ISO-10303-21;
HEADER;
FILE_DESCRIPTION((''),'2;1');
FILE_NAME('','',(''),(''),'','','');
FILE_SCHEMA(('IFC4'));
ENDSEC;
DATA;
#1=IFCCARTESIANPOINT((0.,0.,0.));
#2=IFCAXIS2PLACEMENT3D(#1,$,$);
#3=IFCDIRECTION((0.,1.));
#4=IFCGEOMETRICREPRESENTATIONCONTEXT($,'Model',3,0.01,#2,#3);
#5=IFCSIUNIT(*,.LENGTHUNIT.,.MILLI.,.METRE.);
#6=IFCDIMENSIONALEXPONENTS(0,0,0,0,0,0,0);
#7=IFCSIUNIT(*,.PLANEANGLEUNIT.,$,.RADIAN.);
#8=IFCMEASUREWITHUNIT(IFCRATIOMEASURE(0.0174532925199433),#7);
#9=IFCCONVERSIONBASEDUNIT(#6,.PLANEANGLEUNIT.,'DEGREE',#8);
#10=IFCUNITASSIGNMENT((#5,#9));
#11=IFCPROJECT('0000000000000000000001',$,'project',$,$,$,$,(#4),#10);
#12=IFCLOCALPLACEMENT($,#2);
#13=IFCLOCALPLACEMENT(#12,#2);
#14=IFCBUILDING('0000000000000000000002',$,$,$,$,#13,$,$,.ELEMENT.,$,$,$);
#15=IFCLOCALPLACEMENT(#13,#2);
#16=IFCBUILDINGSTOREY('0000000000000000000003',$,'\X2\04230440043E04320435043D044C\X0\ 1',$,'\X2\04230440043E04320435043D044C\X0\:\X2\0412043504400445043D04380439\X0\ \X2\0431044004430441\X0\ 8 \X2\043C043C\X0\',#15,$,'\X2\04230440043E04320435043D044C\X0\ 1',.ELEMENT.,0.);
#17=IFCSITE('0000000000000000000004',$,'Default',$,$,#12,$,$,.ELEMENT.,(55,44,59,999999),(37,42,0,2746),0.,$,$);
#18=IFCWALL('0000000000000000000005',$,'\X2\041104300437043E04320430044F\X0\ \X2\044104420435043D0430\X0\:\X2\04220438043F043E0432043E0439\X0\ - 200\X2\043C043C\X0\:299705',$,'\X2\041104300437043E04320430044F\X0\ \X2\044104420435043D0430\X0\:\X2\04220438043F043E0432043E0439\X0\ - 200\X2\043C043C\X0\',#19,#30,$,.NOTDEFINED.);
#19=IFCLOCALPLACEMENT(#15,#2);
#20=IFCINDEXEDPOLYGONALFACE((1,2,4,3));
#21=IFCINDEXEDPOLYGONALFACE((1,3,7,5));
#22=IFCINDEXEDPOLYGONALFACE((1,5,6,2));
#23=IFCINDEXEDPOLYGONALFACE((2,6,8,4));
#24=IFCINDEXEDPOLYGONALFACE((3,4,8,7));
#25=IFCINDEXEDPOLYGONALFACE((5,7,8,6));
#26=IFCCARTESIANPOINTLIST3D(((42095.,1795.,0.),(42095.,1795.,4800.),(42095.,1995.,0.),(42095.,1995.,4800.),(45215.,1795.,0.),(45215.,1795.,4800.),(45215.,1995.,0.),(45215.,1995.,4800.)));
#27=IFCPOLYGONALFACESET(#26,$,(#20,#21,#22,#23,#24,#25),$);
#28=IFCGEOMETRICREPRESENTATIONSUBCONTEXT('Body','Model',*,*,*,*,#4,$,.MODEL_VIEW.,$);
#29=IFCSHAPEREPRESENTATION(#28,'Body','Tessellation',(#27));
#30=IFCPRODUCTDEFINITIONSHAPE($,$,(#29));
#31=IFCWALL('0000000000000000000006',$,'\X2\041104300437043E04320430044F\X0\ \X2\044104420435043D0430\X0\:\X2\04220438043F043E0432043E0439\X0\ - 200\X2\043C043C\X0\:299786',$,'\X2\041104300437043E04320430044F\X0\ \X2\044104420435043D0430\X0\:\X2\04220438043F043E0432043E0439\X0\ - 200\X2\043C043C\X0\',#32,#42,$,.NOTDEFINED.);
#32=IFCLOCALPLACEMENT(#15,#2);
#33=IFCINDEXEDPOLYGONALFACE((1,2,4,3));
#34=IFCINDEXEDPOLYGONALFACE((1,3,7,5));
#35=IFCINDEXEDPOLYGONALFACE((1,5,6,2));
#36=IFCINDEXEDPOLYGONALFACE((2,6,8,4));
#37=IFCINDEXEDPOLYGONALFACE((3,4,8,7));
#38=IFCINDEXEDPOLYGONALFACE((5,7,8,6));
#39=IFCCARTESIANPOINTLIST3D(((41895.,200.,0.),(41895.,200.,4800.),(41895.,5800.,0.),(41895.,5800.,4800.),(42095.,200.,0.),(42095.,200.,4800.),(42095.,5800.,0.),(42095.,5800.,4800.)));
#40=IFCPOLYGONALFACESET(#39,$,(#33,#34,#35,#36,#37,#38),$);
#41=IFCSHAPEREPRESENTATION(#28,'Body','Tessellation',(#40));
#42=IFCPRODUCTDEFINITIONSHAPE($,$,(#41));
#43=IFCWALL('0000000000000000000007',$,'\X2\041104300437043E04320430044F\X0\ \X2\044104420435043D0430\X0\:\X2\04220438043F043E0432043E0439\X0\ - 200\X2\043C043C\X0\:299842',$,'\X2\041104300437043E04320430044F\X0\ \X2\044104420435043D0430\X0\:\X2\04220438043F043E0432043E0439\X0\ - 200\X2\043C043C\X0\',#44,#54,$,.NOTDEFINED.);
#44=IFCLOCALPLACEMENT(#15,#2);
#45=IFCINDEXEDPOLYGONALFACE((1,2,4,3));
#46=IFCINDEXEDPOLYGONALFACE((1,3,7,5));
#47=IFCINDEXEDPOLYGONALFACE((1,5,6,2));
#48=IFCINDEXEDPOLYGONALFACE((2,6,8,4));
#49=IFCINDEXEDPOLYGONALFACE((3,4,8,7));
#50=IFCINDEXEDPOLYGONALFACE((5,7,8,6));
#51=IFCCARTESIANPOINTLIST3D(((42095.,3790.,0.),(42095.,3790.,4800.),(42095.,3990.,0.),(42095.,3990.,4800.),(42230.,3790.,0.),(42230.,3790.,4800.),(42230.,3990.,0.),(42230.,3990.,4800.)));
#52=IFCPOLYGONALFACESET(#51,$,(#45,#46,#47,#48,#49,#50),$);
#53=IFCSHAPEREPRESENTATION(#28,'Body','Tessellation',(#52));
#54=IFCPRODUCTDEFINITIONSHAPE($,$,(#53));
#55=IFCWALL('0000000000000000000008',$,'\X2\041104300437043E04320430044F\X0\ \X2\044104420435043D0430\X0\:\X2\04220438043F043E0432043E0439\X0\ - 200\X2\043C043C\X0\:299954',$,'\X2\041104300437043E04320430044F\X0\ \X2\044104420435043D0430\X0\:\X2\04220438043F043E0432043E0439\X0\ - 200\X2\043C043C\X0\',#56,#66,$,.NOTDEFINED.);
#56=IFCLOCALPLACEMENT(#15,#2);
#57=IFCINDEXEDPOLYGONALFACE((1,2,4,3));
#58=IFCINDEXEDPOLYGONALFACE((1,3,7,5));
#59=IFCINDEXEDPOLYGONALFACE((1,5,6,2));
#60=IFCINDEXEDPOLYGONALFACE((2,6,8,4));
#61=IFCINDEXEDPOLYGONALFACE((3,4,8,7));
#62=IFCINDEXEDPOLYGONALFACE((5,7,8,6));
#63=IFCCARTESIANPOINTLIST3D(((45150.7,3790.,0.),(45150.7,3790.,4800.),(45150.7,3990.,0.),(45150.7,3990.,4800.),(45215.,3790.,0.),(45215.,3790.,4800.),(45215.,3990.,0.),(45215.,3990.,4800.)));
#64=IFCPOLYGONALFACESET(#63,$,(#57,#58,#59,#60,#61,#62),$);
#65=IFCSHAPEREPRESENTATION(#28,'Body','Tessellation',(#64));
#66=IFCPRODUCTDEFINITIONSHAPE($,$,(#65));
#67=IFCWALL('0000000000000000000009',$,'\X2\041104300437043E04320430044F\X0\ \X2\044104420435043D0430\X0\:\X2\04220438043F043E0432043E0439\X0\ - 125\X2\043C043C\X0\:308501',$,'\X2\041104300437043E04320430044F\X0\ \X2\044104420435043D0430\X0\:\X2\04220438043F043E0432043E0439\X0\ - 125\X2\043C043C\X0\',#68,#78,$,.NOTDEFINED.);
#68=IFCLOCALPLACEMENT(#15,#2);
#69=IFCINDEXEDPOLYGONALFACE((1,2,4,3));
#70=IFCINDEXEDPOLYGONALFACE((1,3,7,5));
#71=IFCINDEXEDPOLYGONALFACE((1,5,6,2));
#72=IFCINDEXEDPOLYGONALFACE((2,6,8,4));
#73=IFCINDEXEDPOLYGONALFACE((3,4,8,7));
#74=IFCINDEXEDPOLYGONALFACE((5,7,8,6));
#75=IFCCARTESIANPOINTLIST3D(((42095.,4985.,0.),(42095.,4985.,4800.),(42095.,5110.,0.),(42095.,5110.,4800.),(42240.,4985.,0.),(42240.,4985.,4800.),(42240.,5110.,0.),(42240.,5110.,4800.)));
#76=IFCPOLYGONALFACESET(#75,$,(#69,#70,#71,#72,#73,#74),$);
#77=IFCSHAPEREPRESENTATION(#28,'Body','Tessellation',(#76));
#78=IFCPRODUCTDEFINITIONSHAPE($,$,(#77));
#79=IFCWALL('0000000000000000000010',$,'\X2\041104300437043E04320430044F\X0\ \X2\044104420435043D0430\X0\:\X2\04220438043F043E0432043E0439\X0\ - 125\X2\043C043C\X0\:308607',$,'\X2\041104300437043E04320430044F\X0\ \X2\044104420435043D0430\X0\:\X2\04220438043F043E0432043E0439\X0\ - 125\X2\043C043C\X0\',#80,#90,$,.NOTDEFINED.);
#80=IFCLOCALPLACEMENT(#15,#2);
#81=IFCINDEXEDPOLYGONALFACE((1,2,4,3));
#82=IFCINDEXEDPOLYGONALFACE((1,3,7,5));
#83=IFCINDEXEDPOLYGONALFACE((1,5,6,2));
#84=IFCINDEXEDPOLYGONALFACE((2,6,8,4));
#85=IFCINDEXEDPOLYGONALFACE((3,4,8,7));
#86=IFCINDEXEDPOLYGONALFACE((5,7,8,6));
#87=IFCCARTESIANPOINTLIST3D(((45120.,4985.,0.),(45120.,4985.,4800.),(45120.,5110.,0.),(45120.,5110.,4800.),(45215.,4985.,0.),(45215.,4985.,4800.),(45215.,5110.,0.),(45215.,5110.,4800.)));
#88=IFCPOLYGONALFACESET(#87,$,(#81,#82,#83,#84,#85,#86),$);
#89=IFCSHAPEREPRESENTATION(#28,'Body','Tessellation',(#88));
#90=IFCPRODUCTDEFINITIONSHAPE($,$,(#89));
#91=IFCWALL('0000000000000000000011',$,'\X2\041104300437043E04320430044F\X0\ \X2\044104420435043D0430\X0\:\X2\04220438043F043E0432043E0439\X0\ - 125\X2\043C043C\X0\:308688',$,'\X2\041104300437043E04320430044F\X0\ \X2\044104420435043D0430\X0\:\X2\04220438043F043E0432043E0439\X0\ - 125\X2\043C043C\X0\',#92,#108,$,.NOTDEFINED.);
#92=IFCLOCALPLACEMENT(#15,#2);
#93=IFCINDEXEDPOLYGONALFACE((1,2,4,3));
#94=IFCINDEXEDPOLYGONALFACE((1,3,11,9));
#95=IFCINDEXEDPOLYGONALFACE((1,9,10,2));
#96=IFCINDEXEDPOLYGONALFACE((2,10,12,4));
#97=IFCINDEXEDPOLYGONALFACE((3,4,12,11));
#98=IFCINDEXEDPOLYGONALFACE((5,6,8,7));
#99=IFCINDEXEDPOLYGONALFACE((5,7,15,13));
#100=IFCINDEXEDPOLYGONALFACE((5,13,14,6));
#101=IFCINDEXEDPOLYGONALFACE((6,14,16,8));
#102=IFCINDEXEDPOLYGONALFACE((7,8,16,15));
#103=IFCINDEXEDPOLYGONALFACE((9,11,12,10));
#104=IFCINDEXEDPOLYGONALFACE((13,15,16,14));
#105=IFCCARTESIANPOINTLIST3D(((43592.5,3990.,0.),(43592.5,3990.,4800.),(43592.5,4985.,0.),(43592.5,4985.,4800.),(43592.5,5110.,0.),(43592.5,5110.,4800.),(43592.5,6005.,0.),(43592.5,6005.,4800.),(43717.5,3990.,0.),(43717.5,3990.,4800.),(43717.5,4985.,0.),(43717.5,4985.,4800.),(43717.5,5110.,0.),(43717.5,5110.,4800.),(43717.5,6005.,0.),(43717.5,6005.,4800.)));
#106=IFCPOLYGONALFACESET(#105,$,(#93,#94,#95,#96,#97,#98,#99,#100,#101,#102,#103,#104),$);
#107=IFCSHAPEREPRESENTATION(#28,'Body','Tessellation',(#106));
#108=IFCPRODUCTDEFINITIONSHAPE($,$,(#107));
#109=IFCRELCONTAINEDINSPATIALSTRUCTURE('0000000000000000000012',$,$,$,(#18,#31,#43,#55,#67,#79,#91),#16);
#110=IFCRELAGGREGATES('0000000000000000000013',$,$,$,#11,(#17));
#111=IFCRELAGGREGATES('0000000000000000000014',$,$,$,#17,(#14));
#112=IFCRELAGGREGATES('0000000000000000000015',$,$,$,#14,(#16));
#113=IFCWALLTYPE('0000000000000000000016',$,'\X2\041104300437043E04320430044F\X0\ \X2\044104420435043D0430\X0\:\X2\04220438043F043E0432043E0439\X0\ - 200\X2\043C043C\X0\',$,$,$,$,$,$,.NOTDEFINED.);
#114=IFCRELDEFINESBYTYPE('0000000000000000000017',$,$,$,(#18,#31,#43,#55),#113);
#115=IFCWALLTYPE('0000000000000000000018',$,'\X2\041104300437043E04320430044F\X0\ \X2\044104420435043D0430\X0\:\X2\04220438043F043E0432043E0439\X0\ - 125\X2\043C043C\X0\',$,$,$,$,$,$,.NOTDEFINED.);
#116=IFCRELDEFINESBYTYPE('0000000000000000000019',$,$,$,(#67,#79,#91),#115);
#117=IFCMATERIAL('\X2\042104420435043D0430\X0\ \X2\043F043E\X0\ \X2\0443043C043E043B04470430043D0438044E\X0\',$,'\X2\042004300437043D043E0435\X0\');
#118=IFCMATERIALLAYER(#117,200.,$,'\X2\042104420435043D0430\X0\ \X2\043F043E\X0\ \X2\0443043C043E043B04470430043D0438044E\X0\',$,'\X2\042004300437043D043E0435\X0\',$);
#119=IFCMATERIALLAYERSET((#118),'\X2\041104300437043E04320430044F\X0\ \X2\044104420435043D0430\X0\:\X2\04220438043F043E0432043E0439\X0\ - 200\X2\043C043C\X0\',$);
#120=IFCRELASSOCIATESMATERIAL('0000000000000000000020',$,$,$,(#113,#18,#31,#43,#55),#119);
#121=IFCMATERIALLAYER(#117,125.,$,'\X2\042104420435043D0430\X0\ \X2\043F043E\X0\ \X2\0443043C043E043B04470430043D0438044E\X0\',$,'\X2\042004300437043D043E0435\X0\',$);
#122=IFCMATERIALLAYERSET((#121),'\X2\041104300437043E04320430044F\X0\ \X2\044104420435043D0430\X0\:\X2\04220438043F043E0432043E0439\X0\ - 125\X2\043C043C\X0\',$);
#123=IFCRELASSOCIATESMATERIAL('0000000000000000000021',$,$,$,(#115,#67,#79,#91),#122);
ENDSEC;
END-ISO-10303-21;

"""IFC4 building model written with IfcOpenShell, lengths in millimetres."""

from ifc_helpers import new_model, entity, si_unit, converted_unit, direction, frame, frame_2d, origin, place, context, subcontext, project, spatial, rectangle, extrude, material, layer, layer_set, layer_usage, type_object, element, save


model = new_model("IFC4")

# Units and contexts
model_context = context("Model", 3, precision=0.01, world=origin(), true_north=direction((0.0, 1.0)))
body_context = subcontext(model_context, "Body", "Model", "MODEL_VIEW")
ifc_project = project(units=[si_unit("LENGTHUNIT", "METRE", prefix="MILLI"), converted_unit("PLANEANGLEUNIT", "DEGREE", entity("IfcRatioMeasure", 0.0174532925199433), si_unit("PLANEANGLEUNIT", "RADIAN"), dimensions=[0, 0, 0, 0, 0, 0, 0])], contexts=[model_context])

# Site, building, storey
site_placement = place(None, origin())
site = spatial("IfcSite", under=ifc_project, at=site_placement, Name="Default", CompositionType="ELEMENT", RefLatitude=(55, 44, 59, 999999), RefLongitude=(37, 42, 0, 2746), RefElevation=0.0)
building_placement = place(site_placement, origin())
building = spatial("IfcBuilding", under=site, at=building_placement, CompositionType="ELEMENT")
storey_placement = place(building_placement, origin())
storey = spatial("IfcBuildingStorey", under=building, at=storey_placement, Name="Уровень 1", ObjectType="Уровень:Верхний брус 8 мм", LongName="Уровень 1", CompositionType="ELEMENT", Elevation=0.0)

# Shared definitions
ifc_material_1 = material(Name="Стена по умолчанию", Category="Разное")
ifc_layer_1 = layer(ifc_material_1, 200.0, Name="Стена по умолчанию", Category="Разное")
ifc_layer_set_1 = layer_set([ifc_layer_1], Name="Базовая стена:Типовой - 200мм")
wall_type_1 = type_object("IfcWallType", Name="Базовая стена:Типовой - 200мм", PredefinedType="NOTDEFINED", material=ifc_layer_set_1)

# Walls
ifc_layer_usage_1 = layer_usage(ifc_layer_set_1, "AXIS2", "NEGATIVE", 100.0)
wall_1_placement = place(storey_placement, frame((45215.0, 1895.0, 0.0), z_axis=(0.0, 0.0, 1.0), x_axis=(-1.0, 0.0, 0.0)))
element("IfcWall", 1, at=wall_1_placement, inside=storey, type_object=wall_type_1, material=ifc_layer_usage_1, Name="Базовая стена:Типовой - 200мм:299705", ObjectType="Базовая стена:Типовой - 200мм", PredefinedType="NOTDEFINED", context=body_context, shape_type="SweptSolid", body=[
    extrude(rectangle(XDim=3120.0, YDim=200.0, at=frame_2d((1560.0, 0.0), x_axis=(-1.0, 0.0))), origin(), (0.0, 0.0, 1.0), 4800.0),
])
ifc_layer_usage_2 = layer_usage(ifc_layer_set_1, "AXIS2", "NEGATIVE", 100.0)
wall_2_placement = place(storey_placement, frame((41995.0, 5800.0, 0.0), z_axis=(0.0, 0.0, 1.0), x_axis=(0.0, -1.0, 0.0)))
element("IfcWall", 2, at=wall_2_placement, inside=storey, type_object=wall_type_1, material=ifc_layer_usage_2, Name="Базовая стена:Типовой - 200мм:299786", ObjectType="Базовая стена:Типовой - 200мм", PredefinedType="NOTDEFINED", context=body_context, shape_type="SweptSolid", body=[
    extrude(rectangle(XDim=5600.0, YDim=200.0, at=frame_2d((2800.0, 0.0), x_axis=(-1.0, 0.0))), origin(), (0.0, 0.0, 1.0), 4800.0),
])
ifc_layer_usage_3 = layer_usage(ifc_layer_set_1, "AXIS2", "NEGATIVE", 100.0)
wall_3_placement = place(storey_placement, frame((42095.0, 3890.0, 0.0)))
element("IfcWall", 3, at=wall_3_placement, inside=storey, type_object=wall_type_1, material=ifc_layer_usage_3, Name="Базовая стена:Типовой - 200мм:299842", ObjectType="Базовая стена:Типовой - 200мм", PredefinedType="NOTDEFINED", context=body_context, shape_type="SweptSolid", body=[
    extrude(rectangle(XDim=135.0, YDim=200.0, at=frame_2d((67.5, 0.0), x_axis=(-1.0, 0.0))), origin(), (0.0, 0.0, 1.0), 4800.0),
])

# Walls
ifc_layer_usage_4 = layer_usage(ifc_layer_set_1, "AXIS2", "NEGATIVE", 100.0)
wall_4_placement = place(storey_placement, frame((45150.7, 3890.0, 0.0)))
element("IfcWall", 4, at=wall_4_placement, inside=storey, type_object=wall_type_1, material=ifc_layer_usage_4, Name="Базовая стена:Типовой - 200мм:299954", ObjectType="Базовая стена:Типовой - 200мм", PredefinedType="NOTDEFINED", context=body_context, shape_type="SweptSolid", body=[
    extrude(rectangle(XDim=64.3, YDim=200.0, at=frame_2d((32.1, 0.0), x_axis=(-1.0, 0.0))), origin(), (0.0, 0.0, 1.0), 4800.0),
])
ifc_layer_2 = layer(ifc_material_1, 125.0, Name="Стена по умолчанию", Category="Разное")
ifc_layer_set_2 = layer_set([ifc_layer_2], Name="Базовая стена:Типовой - 125мм")
ifc_layer_usage_5 = layer_usage(ifc_layer_set_2, "AXIS2", "NEGATIVE", 62.5)
wall_type_2 = type_object("IfcWallType", Name="Базовая стена:Типовой - 125мм", PredefinedType="NOTDEFINED", material=ifc_layer_set_2)
wall_5_placement = place(storey_placement, frame((42095.0, 5047.5, 0.0)))
element("IfcWall", 5, at=wall_5_placement, inside=storey, type_object=wall_type_2, material=ifc_layer_usage_5, Name="Базовая стена:Типовой - 125мм:308501", ObjectType="Базовая стена:Типовой - 125мм", PredefinedType="NOTDEFINED", context=body_context, shape_type="SweptSolid", body=[
    extrude(rectangle(XDim=145.0, YDim=125.0, at=frame_2d((72.5, 0.0), x_axis=(-1.0, 0.0))), origin(), (0.0, 0.0, 1.0), 4800.0),
])

# Wall
ifc_layer_usage_6 = layer_usage(ifc_layer_set_2, "AXIS2", "NEGATIVE", 62.5)
wall_6_placement = place(storey_placement, frame((45120.0, 5047.5, 0.0)))
element("IfcWall", 6, at=wall_6_placement, inside=storey, type_object=wall_type_2, material=ifc_layer_usage_6, Name="Базовая стена:Типовой - 125мм:308607", ObjectType="Базовая стена:Типовой - 125мм", PredefinedType="NOTDEFINED", context=body_context, shape_type="SweptSolid", body=[
    extrude(rectangle(XDim=95.0, YDim=125.0, at=frame_2d((47.5, 0.0), x_axis=(-1.0, 0.0))), origin(), (0.0, 0.0, 1.0), 4800.0),
])

# Wall, opening
ifc_layer_usage_7 = layer_usage(ifc_layer_set_2, "AXIS2", "NEGATIVE", 62.5)
wall_7_placement = place(storey_placement, frame((43655.0, 6005.0, 0.0), z_axis=(0.0, 0.0, 1.0), x_axis=(0.0, -1.0, 0.0)))
wall_7 = element("IfcWall", 7, at=wall_7_placement, inside=storey, type_object=wall_type_2, material=ifc_layer_usage_7, Name="Базовая стена:Типовой - 125мм:308688", ObjectType="Базовая стена:Типовой - 125мм", PredefinedType="NOTDEFINED", context=body_context, shape_type="SweptSolid", body=[
    extrude(rectangle(XDim=2015.0, YDim=125.0, at=frame_2d((1007.5, 0.0), x_axis=(-1.0, 0.0))), origin(), (0.0, 0.0, 1.0), 4800.0),
])
opening_1_placement = place(storey_placement, frame((43655.0, 6005.0, 0.0), z_axis=(0.0, 0.0, 1.0), x_axis=(0.0, -1.0, 0.0)))
element("IfcOpeningElement", 8, at=opening_1_placement, cuts=wall_7, ObjectType="Opening", PredefinedType="OPENING", context=body_context, shape_type="SweptSolid", body=[
    extrude(rectangle(XDim=4800.0, YDim=125.0, at=frame_2d((0.0, 0.0), x_axis=(1.0, 0.0))), frame((1020.0, 0.0, 2400.0), z_axis=(-1.0, 0.0, 0.0), x_axis=(0.0, 0.0, 1.0)), (0.0, 0.0, 1.0), 125.0),
])

save(model, "model.ifc")
